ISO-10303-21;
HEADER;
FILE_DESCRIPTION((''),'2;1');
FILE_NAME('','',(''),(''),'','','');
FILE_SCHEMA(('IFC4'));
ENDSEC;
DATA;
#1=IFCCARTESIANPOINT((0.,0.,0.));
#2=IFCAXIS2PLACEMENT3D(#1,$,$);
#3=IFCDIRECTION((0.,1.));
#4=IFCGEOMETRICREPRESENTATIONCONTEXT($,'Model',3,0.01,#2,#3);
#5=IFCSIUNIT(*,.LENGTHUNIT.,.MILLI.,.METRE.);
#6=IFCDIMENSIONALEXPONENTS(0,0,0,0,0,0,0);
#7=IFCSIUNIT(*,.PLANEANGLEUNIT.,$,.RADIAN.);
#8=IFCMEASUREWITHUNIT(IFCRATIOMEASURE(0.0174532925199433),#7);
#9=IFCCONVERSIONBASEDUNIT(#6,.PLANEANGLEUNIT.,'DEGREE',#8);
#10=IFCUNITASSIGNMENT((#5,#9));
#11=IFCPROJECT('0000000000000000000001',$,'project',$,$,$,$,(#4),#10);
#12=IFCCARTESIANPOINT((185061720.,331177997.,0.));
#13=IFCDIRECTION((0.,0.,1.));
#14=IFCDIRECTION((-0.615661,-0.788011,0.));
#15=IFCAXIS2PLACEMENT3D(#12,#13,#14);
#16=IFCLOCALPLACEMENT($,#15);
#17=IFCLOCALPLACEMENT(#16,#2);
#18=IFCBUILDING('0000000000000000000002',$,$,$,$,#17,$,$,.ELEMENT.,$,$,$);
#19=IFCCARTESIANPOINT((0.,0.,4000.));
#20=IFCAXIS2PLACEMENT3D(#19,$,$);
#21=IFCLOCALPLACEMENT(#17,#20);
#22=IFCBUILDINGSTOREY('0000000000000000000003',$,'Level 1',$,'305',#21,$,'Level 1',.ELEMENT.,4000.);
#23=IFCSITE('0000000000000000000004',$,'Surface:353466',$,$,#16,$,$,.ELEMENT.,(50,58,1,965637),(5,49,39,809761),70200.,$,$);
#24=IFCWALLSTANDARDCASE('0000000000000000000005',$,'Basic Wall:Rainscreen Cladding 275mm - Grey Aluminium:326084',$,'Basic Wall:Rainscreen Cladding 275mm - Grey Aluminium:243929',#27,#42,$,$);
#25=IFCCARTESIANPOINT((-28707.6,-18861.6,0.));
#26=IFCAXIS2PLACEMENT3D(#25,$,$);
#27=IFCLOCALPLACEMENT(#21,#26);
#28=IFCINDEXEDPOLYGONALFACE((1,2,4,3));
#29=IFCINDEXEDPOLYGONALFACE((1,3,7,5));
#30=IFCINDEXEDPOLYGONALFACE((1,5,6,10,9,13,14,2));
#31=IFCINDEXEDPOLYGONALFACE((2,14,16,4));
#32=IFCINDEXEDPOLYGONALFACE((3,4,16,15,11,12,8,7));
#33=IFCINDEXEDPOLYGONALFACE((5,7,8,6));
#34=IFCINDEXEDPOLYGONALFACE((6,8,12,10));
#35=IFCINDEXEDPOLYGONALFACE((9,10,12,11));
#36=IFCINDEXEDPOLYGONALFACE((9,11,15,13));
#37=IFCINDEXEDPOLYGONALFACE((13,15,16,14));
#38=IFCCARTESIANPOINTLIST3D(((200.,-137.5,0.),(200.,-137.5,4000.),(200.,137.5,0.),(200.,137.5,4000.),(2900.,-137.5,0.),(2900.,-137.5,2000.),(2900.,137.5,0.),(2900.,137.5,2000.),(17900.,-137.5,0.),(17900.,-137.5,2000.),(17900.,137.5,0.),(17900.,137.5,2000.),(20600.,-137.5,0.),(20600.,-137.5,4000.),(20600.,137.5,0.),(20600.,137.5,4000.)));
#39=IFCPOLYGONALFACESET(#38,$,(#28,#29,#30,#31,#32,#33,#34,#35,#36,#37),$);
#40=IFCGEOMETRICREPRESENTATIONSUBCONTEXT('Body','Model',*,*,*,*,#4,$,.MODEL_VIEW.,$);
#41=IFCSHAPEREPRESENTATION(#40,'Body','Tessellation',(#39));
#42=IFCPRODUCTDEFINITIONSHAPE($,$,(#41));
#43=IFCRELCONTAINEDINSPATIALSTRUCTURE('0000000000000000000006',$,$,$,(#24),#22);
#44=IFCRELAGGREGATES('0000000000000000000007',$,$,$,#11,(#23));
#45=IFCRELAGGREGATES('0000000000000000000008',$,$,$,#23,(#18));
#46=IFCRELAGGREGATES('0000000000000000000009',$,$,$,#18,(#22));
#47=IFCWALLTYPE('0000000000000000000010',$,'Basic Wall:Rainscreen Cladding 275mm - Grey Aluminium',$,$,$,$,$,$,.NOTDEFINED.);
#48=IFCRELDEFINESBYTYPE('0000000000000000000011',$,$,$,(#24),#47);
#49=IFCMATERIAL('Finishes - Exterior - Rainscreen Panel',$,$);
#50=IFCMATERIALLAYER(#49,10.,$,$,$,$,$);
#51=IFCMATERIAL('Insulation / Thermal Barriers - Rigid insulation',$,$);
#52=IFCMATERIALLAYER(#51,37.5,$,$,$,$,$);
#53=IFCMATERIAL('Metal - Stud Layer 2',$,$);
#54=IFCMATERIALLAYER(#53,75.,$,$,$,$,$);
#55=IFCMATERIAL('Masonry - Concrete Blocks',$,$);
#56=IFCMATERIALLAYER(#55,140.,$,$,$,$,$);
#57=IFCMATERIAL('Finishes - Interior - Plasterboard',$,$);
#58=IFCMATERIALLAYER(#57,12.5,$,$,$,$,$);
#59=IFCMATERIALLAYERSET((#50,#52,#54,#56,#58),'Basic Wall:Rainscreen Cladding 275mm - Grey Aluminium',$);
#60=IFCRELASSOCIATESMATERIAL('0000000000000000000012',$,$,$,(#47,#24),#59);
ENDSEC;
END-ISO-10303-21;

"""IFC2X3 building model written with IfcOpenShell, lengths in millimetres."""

from ifc_helpers import new_model, entity, si_unit, converted_unit, direction, frame, frame_2d, origin, place, context, subcontext, project, spatial, rectangle, extrude, clip, halfspace, material, layer, layer_set, layer_usage, type_object, element, save


model = new_model("IFC2X3")

# Units and contexts
model_context = context("Model", 3, precision=0.01, world=origin(), true_north=direction((0.0, 1.0)))
body_context = subcontext(model_context, "Body", "Model", "MODEL_VIEW")
ifc_project = project(units=[si_unit("LENGTHUNIT", "METRE", prefix="MILLI"), converted_unit("PLANEANGLEUNIT", "DEGREE", entity("IfcRatioMeasure", 0.0174532925199433), si_unit("PLANEANGLEUNIT", "RADIAN"), dimensions=[0, 0, 0, 0, 0, 0, 0])], contexts=[model_context])

# Site, building, storey
site_placement = place(None, frame((185061720.0, 331177997.0, 0.0), z_axis=(0.0, 0.0, 1.0), x_axis=(-0.615661, -0.788011, 0.0)))
site = spatial("IfcSite", under=ifc_project, at=site_placement, Name="Surface:353466", CompositionType="ELEMENT", RefLatitude=(50, 58, 1, 965637), RefLongitude=(5, 49, 39, 809761), RefElevation=70200.0)
building_placement = place(site_placement, origin())
building = spatial("IfcBuilding", under=site, at=building_placement, CompositionType="ELEMENT")
storey_placement = place(building_placement, frame((0.0, 0.0, 4000.0)))
storey = spatial("IfcBuildingStorey", under=building, at=storey_placement, Name="Level 1", ObjectType="305", LongName="Level 1", CompositionType="ELEMENT", Elevation=4000.0)

# Wall, opening
ifc_material_1 = material(Name="Finishes - Exterior - Rainscreen Panel")
ifc_layer_1 = layer(ifc_material_1, 10.0)
ifc_material_2 = material(Name="Insulation / Thermal Barriers - Rigid insulation")
ifc_layer_2 = layer(ifc_material_2, 37.5)
ifc_material_3 = material(Name="Metal - Stud Layer 2")
ifc_layer_3 = layer(ifc_material_3, 75.0)
ifc_material_4 = material(Name="Masonry - Concrete Blocks")
ifc_layer_4 = layer(ifc_material_4, 140.0)
ifc_material_5 = material(Name="Finishes - Interior - Plasterboard")
ifc_layer_5 = layer(ifc_material_5, 12.5)
ifc_layer_set_1 = layer_set([ifc_layer_1, ifc_layer_2, ifc_layer_3, ifc_layer_4, ifc_layer_5], Name="Basic Wall:Rainscreen Cladding 275mm - Grey Aluminium")
ifc_layer_usage_1 = layer_usage(ifc_layer_set_1, "AXIS2", "POSITIVE", -137.5)
wall_type_1 = type_object("IfcWallType", Name="Basic Wall:Rainscreen Cladding 275mm - Grey Aluminium", PredefinedType="NOTDEFINED", material=ifc_layer_set_1)
wall_1_placement = place(storey_placement, frame((-28707.6, -18861.6, 0.0)))
wall_1 = element("IfcWallStandardCase", 1, at=wall_1_placement, inside=storey, type_object=wall_type_1, material=ifc_layer_usage_1, Name="Basic Wall:Rainscreen Cladding 275mm - Grey Aluminium:326084", ObjectType="Basic Wall:Rainscreen Cladding 275mm - Grey Aluminium:243929", context=body_context, shape_type="Clipping", body=[
    clip(extrude(rectangle(XDim=20400.0, YDim=275.0, at=frame_2d((10400.0, 0.0), x_axis=(1.0, 0.0))), origin(), (0.0, 0.0, 1.0), 4000.0), halfspace(frame((0.0, 0.0, -4000.0)), True)),
])
opening_placement = place(wall_1_placement, origin())
element("IfcOpeningElement", 2, at=opening_placement, cuts=wall_1, ObjectType="Opening", context=body_context, shape_type="SweptSolid", body=[
    extrude(rectangle(XDim=2000.0, YDim=15000.0, at=frame_2d((0.0, 0.0), x_axis=(1.0, 0.0))), frame((10400.0, -289.9, 1000.0), z_axis=(0.0, 1.0, 0.0), x_axis=(0.0, 0.0, 1.0)), (0.0, 0.0, 1.0), 579.8),
])

save(model, "model.ifc")
